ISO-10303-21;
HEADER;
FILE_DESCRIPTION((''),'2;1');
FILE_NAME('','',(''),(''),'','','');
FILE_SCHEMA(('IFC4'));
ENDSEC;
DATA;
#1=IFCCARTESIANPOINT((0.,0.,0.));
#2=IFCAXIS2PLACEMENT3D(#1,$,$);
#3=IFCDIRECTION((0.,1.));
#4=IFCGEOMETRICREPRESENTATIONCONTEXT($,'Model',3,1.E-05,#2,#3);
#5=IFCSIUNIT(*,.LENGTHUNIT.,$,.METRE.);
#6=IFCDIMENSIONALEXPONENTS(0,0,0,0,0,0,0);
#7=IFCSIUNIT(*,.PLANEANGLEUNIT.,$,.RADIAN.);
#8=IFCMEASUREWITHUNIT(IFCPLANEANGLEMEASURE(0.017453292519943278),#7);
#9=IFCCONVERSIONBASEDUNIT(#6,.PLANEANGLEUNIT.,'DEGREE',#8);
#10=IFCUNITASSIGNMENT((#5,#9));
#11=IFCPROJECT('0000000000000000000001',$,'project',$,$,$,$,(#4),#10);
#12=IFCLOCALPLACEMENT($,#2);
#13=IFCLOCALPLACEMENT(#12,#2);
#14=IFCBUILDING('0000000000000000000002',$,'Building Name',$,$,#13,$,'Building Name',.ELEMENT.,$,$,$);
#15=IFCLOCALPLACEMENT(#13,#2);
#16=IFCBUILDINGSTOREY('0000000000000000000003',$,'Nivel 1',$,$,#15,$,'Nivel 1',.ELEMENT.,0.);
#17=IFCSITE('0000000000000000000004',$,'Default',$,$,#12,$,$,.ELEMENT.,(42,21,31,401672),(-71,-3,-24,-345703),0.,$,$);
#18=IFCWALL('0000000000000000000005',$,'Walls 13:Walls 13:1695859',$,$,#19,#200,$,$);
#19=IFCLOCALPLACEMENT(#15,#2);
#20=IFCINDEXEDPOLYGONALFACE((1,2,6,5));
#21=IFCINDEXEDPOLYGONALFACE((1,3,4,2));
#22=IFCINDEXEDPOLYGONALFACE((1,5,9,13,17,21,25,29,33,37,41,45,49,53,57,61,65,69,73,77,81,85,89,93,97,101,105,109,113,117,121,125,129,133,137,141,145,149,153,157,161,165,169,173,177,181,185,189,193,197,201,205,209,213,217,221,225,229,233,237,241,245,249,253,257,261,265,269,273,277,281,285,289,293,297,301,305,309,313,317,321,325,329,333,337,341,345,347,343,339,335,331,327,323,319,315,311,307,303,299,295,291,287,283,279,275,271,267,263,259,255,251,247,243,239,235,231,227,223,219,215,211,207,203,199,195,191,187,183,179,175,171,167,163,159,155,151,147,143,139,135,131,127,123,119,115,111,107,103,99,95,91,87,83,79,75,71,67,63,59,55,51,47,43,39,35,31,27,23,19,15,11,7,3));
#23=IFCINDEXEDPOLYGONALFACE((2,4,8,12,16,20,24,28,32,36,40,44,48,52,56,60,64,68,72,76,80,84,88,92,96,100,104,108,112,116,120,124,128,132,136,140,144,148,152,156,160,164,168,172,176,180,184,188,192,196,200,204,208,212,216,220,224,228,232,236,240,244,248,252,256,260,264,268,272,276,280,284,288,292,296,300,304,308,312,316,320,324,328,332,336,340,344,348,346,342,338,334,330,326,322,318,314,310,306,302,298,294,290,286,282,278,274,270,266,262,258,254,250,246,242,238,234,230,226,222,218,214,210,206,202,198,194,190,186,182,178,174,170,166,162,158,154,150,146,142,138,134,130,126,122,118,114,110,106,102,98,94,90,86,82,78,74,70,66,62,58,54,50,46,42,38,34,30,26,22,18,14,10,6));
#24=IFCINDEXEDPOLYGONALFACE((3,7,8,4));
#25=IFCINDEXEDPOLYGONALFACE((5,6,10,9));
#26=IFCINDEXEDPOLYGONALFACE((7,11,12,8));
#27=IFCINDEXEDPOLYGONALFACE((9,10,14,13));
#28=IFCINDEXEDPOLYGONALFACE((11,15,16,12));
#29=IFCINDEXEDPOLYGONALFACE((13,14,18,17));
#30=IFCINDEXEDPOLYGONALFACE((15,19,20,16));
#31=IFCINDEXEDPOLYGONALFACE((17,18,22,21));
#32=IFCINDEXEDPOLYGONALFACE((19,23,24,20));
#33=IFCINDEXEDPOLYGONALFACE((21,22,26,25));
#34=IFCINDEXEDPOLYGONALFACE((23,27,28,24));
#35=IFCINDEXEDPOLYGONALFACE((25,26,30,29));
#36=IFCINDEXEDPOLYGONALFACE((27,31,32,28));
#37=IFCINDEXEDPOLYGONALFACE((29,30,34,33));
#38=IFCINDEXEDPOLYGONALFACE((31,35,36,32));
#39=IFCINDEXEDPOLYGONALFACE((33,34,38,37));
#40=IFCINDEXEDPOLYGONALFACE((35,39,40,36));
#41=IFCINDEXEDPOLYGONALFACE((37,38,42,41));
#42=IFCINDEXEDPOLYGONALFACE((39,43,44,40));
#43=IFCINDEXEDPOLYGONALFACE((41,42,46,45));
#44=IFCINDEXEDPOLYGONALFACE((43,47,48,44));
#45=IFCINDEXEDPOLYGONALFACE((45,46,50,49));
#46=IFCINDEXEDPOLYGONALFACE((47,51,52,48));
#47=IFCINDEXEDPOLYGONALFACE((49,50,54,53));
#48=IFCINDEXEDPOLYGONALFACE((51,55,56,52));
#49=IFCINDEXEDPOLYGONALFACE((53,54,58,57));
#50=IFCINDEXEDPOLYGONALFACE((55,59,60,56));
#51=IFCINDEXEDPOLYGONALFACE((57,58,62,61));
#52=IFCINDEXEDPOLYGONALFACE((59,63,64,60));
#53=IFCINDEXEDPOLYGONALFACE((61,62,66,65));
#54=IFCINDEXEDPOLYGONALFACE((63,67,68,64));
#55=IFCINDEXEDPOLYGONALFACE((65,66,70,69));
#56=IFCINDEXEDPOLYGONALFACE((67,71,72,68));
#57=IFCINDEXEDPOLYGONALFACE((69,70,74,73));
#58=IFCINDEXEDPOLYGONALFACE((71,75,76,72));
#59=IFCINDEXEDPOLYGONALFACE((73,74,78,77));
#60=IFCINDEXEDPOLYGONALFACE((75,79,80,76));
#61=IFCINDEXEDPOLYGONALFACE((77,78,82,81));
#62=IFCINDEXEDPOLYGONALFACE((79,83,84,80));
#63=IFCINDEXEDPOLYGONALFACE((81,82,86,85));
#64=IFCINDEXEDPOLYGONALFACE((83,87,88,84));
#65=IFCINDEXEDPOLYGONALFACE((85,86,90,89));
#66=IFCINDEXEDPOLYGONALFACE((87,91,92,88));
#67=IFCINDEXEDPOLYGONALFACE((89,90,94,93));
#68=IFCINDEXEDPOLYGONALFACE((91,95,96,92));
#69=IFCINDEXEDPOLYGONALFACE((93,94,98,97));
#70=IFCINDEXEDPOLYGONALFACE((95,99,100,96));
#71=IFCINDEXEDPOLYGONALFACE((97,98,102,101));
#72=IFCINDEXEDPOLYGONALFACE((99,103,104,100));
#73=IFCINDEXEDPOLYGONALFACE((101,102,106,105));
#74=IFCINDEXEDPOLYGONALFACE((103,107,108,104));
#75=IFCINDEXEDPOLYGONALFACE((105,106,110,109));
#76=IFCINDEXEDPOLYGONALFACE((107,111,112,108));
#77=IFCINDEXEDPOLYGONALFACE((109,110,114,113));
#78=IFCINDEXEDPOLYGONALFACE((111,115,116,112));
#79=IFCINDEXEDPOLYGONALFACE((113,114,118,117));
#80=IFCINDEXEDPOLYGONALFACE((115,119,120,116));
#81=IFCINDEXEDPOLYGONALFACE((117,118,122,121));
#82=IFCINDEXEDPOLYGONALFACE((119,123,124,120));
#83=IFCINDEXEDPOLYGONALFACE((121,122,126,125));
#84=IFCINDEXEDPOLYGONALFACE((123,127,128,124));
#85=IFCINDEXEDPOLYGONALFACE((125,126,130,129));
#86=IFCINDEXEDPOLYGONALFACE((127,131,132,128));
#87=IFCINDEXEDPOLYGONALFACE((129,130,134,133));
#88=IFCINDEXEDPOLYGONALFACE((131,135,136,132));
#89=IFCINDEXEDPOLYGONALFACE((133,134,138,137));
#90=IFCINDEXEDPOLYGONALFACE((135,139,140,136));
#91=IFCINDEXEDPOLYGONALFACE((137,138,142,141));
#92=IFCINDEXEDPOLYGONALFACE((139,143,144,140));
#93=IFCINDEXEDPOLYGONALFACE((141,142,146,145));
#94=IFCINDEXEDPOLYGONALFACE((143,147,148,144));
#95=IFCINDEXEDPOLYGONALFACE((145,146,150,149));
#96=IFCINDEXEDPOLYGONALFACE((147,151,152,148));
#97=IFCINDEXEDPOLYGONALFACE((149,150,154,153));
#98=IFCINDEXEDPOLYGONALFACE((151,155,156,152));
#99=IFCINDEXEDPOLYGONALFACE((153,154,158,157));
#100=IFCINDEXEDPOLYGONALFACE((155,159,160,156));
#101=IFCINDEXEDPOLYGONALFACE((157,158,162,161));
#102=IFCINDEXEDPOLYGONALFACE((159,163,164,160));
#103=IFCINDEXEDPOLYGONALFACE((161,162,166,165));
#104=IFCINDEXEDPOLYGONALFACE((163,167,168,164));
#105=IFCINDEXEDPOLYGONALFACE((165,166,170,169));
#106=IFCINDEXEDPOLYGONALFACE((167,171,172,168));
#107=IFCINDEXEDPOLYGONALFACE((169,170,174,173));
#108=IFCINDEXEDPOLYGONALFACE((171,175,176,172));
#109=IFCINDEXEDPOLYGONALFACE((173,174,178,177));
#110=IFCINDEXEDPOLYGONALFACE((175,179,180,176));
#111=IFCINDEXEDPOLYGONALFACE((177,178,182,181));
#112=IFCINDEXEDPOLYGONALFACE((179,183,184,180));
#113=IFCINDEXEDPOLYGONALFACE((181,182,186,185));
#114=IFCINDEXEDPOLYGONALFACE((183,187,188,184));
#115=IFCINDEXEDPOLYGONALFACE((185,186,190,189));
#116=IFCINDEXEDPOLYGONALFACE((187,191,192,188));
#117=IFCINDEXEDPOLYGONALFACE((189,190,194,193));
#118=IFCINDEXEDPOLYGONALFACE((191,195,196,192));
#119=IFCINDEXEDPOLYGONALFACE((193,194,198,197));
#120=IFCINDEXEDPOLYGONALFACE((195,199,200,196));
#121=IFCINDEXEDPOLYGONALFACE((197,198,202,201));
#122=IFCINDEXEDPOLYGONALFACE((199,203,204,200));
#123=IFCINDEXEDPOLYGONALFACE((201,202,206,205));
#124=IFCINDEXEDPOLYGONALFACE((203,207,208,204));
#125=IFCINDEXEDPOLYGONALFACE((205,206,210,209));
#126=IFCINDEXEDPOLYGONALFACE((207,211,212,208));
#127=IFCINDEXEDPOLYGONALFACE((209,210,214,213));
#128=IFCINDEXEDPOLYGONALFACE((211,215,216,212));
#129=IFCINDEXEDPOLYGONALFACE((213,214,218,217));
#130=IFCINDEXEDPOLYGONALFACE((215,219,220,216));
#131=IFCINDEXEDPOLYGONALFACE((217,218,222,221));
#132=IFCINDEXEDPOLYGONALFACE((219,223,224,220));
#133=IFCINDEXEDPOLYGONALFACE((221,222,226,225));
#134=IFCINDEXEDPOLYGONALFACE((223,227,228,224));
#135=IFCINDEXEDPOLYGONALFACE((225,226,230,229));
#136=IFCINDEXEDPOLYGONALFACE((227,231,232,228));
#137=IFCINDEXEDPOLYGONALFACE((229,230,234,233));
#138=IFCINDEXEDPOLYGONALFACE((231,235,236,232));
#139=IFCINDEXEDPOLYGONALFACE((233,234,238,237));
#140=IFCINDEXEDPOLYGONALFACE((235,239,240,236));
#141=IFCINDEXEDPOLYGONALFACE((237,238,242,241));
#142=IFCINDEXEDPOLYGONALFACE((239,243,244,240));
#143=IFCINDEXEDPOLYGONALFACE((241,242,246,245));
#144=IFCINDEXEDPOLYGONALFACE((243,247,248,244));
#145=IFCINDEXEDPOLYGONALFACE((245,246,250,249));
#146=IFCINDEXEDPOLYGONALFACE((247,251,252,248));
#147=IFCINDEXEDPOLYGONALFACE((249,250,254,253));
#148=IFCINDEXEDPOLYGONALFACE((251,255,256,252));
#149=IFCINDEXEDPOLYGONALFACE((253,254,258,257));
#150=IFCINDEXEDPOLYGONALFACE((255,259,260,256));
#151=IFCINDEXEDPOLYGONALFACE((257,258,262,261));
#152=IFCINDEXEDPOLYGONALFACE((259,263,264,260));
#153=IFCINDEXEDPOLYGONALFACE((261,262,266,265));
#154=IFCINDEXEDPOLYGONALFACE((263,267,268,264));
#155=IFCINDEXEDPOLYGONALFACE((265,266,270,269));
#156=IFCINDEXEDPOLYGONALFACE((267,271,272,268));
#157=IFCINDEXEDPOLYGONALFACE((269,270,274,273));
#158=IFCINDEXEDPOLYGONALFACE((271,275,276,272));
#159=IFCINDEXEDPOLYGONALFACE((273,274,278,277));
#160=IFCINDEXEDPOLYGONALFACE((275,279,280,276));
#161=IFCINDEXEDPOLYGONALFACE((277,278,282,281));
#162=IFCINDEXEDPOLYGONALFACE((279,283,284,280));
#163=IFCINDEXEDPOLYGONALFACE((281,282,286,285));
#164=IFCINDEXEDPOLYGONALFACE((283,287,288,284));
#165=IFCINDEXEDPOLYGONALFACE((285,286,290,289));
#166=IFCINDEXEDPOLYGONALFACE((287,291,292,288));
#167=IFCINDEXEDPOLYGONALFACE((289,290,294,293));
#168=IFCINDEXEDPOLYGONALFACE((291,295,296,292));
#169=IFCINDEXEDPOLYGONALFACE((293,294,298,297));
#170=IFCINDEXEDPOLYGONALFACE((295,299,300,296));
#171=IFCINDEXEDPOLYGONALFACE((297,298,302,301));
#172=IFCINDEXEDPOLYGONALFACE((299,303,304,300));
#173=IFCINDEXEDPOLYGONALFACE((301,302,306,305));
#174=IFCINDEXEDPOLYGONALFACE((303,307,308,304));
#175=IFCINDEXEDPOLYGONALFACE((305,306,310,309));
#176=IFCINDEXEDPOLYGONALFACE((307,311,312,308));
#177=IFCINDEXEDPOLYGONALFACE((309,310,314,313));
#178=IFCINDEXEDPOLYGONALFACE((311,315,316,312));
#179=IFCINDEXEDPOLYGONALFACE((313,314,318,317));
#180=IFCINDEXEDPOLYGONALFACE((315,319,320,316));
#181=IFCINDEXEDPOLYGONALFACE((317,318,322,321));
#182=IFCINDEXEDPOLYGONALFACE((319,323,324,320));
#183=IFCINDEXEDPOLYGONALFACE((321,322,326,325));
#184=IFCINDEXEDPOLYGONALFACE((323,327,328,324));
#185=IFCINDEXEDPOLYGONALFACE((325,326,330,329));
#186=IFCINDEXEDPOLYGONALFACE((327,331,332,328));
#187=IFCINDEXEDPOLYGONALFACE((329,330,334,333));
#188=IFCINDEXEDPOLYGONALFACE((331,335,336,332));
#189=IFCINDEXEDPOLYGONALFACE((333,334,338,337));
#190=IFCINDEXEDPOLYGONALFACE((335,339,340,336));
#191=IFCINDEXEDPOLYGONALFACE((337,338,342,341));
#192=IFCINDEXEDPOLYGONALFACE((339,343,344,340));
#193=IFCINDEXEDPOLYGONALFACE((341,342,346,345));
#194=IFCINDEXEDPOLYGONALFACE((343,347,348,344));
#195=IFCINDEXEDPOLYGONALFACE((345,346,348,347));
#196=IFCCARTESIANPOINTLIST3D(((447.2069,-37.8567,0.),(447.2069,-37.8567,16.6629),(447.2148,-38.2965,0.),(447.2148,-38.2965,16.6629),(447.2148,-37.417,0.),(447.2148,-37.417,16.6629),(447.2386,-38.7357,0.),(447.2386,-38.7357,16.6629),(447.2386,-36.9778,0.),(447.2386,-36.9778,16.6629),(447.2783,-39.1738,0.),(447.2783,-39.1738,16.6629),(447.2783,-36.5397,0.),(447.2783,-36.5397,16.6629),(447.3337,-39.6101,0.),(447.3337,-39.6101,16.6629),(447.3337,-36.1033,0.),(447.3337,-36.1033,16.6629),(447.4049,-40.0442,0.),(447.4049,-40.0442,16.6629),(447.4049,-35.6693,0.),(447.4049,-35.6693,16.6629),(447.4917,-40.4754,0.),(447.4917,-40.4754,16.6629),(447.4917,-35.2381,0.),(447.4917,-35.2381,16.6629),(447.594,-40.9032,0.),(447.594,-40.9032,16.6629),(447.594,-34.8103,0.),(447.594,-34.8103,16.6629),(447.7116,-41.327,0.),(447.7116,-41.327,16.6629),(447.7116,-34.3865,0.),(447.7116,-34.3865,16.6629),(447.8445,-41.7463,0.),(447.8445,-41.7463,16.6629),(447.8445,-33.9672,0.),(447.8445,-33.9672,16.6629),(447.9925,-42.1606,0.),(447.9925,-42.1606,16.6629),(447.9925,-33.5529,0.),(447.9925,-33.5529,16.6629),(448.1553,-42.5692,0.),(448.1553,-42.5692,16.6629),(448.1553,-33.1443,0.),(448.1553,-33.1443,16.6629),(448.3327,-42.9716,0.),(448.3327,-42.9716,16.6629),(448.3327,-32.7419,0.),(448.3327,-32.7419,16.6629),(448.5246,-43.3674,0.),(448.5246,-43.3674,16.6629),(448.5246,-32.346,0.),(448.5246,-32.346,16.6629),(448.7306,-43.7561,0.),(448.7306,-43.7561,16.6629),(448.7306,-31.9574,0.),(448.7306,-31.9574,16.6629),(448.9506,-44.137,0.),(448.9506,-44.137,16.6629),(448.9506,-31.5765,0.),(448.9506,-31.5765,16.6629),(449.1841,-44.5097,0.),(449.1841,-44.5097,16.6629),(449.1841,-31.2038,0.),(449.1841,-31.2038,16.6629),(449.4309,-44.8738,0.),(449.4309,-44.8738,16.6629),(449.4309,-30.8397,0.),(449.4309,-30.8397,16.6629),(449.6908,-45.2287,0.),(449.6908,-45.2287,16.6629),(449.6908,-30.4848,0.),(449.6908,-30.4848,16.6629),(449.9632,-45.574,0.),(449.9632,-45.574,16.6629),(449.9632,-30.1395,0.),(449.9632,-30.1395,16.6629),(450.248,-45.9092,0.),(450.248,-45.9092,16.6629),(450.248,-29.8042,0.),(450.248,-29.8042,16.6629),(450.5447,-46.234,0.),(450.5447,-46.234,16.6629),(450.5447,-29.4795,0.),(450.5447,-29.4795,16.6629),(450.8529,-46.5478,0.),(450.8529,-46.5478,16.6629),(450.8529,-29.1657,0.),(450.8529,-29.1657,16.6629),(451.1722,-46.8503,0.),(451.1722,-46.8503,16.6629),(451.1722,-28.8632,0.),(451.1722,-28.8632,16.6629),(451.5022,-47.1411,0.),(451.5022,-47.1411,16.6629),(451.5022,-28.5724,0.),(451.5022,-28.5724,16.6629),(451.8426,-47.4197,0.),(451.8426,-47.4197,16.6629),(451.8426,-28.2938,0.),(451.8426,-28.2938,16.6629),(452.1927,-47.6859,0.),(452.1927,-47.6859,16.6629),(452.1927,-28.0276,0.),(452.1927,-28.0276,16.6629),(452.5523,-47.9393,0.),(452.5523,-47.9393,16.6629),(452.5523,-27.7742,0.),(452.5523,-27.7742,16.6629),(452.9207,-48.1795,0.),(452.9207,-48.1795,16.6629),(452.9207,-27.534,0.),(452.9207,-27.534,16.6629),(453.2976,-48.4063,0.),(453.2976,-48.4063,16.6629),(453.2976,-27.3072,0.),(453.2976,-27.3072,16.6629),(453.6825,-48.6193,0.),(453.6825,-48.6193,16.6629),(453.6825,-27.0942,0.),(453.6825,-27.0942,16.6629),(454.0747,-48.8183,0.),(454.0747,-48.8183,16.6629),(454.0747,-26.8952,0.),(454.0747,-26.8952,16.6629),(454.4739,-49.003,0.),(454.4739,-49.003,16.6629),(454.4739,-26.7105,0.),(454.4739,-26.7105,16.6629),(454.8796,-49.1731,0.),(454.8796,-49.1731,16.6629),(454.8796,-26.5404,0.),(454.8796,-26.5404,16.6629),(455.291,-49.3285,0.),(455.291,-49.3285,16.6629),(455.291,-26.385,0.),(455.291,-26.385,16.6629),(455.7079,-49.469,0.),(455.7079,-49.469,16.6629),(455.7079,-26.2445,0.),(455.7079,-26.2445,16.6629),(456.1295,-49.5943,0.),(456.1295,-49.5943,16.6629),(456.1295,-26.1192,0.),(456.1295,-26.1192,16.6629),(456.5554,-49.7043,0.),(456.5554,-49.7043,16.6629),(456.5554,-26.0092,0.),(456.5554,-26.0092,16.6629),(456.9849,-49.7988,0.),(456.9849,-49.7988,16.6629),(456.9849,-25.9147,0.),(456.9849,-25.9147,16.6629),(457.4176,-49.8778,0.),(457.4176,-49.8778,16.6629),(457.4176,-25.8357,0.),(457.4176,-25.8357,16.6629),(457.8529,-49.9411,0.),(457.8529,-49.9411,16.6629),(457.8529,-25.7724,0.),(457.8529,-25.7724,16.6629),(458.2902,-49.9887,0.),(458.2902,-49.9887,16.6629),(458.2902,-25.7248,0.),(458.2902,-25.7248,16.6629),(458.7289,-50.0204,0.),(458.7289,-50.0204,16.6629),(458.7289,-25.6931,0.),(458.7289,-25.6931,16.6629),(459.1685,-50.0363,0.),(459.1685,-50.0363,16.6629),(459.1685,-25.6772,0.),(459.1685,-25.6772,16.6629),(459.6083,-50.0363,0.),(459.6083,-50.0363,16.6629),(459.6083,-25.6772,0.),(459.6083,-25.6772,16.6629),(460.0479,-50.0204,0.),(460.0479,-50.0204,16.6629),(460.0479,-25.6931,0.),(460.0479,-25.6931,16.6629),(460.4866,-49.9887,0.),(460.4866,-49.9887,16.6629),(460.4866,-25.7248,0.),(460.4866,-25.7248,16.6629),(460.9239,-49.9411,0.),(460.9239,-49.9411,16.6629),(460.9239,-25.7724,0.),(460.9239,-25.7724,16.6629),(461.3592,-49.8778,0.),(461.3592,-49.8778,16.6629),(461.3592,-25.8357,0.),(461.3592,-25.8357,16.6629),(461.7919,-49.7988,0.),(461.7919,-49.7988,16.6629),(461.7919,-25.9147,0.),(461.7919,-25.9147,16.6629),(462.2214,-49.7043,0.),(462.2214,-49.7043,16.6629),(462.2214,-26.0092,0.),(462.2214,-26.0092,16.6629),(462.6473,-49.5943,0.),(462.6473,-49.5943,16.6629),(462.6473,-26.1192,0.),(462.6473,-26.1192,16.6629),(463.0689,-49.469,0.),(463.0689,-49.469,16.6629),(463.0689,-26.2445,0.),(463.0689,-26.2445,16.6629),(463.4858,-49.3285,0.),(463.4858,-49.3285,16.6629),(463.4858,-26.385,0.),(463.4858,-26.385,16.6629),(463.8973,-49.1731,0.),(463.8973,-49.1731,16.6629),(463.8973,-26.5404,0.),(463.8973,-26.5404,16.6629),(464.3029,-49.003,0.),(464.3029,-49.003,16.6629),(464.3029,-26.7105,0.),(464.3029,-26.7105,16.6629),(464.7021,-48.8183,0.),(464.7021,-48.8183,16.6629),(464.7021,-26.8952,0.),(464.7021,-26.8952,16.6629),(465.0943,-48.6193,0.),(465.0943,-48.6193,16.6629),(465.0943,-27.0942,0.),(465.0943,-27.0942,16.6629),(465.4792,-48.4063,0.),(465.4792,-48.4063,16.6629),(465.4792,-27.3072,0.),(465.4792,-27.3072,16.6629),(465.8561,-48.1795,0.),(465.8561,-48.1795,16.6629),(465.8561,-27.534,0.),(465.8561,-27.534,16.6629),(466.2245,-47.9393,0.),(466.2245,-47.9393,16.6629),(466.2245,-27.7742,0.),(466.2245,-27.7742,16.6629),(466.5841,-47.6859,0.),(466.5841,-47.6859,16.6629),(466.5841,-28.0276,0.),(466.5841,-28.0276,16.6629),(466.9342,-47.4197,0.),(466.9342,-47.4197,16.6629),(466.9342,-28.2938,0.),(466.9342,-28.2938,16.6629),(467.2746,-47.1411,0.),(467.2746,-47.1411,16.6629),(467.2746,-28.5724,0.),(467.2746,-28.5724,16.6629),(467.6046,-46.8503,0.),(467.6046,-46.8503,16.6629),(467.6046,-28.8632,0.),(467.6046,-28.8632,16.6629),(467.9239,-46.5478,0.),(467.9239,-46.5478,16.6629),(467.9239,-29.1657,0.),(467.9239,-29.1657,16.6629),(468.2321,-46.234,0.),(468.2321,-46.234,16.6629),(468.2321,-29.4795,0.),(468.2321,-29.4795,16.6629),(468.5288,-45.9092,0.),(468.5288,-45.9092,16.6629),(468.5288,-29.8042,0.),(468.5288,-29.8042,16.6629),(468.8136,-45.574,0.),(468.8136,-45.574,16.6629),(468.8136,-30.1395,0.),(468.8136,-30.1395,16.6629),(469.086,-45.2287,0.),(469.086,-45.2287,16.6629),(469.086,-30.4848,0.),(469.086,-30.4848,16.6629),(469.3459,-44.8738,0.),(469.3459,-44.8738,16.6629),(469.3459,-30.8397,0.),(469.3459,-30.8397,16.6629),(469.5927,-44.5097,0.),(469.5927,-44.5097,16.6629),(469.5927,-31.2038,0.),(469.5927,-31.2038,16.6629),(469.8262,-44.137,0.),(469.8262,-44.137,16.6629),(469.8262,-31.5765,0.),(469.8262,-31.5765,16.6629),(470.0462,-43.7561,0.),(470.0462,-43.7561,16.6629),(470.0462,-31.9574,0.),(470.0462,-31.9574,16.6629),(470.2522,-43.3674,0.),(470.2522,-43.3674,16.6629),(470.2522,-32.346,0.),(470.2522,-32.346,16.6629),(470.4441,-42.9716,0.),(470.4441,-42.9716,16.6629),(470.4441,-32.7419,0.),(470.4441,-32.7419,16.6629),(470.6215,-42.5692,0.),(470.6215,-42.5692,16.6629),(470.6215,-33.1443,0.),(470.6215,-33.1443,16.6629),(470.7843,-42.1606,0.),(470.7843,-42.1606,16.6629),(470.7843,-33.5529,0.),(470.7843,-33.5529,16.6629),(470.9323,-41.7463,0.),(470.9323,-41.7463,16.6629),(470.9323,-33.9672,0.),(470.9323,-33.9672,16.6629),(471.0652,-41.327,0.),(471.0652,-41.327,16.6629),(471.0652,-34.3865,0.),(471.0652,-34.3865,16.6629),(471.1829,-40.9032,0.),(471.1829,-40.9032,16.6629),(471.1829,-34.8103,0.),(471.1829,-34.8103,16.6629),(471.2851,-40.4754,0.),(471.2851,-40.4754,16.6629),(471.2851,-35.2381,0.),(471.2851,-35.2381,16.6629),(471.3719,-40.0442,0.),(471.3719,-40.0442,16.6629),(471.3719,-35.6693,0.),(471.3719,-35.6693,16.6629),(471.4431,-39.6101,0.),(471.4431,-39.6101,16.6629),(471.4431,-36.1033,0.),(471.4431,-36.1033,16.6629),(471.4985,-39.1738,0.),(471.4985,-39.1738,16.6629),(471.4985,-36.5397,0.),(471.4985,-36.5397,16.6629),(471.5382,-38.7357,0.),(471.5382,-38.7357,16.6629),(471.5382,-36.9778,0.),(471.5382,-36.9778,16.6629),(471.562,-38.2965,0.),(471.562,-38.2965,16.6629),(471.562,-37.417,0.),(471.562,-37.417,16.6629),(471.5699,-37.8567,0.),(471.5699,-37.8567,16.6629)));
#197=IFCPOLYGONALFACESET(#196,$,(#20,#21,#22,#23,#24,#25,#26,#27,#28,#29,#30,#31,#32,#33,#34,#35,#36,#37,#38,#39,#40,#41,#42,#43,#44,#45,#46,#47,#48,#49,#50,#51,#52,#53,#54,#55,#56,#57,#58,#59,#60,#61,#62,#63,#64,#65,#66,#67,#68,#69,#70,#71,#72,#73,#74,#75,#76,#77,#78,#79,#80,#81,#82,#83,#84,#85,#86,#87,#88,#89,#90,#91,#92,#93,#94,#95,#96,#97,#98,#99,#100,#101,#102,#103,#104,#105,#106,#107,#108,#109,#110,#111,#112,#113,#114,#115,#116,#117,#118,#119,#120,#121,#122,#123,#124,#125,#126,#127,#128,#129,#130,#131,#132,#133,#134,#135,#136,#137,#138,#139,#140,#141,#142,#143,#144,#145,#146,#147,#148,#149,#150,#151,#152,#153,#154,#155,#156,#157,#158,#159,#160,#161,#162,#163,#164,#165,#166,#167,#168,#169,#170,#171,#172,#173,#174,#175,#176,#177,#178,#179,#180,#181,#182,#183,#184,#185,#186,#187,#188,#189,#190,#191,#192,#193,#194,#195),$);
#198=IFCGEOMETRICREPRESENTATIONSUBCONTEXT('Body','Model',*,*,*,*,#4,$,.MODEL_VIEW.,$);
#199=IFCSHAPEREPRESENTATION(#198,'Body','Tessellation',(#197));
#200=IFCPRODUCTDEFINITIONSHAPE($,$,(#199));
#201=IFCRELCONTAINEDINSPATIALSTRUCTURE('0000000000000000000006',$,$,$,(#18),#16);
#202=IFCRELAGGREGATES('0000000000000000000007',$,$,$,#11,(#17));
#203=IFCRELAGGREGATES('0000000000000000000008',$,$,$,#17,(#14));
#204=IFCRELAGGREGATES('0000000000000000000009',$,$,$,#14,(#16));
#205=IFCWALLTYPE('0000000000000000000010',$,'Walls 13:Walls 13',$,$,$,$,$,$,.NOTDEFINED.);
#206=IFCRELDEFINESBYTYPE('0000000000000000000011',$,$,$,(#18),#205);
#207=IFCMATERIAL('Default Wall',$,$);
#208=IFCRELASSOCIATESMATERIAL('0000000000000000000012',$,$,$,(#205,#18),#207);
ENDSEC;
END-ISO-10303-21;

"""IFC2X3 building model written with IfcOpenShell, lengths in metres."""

from ifc_helpers import new_model, entity, si_unit, converted_unit, direction, frame, frame_2d, origin, place, context, subcontext, project, spatial, circle, extrude, material, type_object, element, save


model = new_model("IFC2X3")

# Units and contexts
model_context = context("Model", 3, precision=1e-05, world=origin(), true_north=direction((0.0, 1.0)))
body_context = subcontext(model_context, "Body", "Model", "MODEL_VIEW")
ifc_project = project(units=[si_unit("LENGTHUNIT", "METRE"), converted_unit("PLANEANGLEUNIT", "DEGREE", entity("IfcPlaneAngleMeasure", 0.017453292519943278), si_unit("PLANEANGLEUNIT", "RADIAN"), dimensions=[0, 0, 0, 0, 0, 0, 0])], contexts=[model_context])

# Site, building, storey
site_placement = place(None, origin())
site = spatial("IfcSite", under=ifc_project, at=site_placement, Name="Default", CompositionType="ELEMENT", RefLatitude=(42, 21, 31, 401672), RefLongitude=(-71, -3, -24, -345703), RefElevation=0.0)
building_placement = place(site_placement, origin())
building = spatial("IfcBuilding", under=site, at=building_placement, Name="Building Name", LongName="Building Name", CompositionType="ELEMENT")
storey_placement = place(building_placement, origin())
storey = spatial("IfcBuildingStorey", under=building, at=storey_placement, Name="Nivel 1", LongName="Nivel 1", CompositionType="ELEMENT", Elevation=0.0)

# Wall
ifc_material_1 = material(Name="Default Wall")
wall_type_1 = type_object("IfcWallType", Name="Walls 13:Walls 13", PredefinedType="NOTDEFINED", material=ifc_material_1)
wall_1_placement = place(storey_placement, frame((447.2069, -50.0383, 0.0), z_axis=(0.0, 0.0, 1.0), x_axis=(0.0, 1.0, 0.0)))
element("IfcWall", 1, at=wall_1_placement, inside=storey, type_object=wall_type_1, material=ifc_material_1, Name="Walls 13:Walls 13:1695859", context=body_context, shape_type="SweptSolid", body=[
    extrude(circle(Radius=12.1815, at=frame_2d((0.0, 0.0), x_axis=(1.0, 0.0))), frame((12.1815, -12.1815, 0.0), z_axis=(0.0, 0.0, 1.0), x_axis=(0.0, -1.0, 0.0)), (0.0, 0.0, 1.0), 16.6629),
])

save(model, "model.ifc")
